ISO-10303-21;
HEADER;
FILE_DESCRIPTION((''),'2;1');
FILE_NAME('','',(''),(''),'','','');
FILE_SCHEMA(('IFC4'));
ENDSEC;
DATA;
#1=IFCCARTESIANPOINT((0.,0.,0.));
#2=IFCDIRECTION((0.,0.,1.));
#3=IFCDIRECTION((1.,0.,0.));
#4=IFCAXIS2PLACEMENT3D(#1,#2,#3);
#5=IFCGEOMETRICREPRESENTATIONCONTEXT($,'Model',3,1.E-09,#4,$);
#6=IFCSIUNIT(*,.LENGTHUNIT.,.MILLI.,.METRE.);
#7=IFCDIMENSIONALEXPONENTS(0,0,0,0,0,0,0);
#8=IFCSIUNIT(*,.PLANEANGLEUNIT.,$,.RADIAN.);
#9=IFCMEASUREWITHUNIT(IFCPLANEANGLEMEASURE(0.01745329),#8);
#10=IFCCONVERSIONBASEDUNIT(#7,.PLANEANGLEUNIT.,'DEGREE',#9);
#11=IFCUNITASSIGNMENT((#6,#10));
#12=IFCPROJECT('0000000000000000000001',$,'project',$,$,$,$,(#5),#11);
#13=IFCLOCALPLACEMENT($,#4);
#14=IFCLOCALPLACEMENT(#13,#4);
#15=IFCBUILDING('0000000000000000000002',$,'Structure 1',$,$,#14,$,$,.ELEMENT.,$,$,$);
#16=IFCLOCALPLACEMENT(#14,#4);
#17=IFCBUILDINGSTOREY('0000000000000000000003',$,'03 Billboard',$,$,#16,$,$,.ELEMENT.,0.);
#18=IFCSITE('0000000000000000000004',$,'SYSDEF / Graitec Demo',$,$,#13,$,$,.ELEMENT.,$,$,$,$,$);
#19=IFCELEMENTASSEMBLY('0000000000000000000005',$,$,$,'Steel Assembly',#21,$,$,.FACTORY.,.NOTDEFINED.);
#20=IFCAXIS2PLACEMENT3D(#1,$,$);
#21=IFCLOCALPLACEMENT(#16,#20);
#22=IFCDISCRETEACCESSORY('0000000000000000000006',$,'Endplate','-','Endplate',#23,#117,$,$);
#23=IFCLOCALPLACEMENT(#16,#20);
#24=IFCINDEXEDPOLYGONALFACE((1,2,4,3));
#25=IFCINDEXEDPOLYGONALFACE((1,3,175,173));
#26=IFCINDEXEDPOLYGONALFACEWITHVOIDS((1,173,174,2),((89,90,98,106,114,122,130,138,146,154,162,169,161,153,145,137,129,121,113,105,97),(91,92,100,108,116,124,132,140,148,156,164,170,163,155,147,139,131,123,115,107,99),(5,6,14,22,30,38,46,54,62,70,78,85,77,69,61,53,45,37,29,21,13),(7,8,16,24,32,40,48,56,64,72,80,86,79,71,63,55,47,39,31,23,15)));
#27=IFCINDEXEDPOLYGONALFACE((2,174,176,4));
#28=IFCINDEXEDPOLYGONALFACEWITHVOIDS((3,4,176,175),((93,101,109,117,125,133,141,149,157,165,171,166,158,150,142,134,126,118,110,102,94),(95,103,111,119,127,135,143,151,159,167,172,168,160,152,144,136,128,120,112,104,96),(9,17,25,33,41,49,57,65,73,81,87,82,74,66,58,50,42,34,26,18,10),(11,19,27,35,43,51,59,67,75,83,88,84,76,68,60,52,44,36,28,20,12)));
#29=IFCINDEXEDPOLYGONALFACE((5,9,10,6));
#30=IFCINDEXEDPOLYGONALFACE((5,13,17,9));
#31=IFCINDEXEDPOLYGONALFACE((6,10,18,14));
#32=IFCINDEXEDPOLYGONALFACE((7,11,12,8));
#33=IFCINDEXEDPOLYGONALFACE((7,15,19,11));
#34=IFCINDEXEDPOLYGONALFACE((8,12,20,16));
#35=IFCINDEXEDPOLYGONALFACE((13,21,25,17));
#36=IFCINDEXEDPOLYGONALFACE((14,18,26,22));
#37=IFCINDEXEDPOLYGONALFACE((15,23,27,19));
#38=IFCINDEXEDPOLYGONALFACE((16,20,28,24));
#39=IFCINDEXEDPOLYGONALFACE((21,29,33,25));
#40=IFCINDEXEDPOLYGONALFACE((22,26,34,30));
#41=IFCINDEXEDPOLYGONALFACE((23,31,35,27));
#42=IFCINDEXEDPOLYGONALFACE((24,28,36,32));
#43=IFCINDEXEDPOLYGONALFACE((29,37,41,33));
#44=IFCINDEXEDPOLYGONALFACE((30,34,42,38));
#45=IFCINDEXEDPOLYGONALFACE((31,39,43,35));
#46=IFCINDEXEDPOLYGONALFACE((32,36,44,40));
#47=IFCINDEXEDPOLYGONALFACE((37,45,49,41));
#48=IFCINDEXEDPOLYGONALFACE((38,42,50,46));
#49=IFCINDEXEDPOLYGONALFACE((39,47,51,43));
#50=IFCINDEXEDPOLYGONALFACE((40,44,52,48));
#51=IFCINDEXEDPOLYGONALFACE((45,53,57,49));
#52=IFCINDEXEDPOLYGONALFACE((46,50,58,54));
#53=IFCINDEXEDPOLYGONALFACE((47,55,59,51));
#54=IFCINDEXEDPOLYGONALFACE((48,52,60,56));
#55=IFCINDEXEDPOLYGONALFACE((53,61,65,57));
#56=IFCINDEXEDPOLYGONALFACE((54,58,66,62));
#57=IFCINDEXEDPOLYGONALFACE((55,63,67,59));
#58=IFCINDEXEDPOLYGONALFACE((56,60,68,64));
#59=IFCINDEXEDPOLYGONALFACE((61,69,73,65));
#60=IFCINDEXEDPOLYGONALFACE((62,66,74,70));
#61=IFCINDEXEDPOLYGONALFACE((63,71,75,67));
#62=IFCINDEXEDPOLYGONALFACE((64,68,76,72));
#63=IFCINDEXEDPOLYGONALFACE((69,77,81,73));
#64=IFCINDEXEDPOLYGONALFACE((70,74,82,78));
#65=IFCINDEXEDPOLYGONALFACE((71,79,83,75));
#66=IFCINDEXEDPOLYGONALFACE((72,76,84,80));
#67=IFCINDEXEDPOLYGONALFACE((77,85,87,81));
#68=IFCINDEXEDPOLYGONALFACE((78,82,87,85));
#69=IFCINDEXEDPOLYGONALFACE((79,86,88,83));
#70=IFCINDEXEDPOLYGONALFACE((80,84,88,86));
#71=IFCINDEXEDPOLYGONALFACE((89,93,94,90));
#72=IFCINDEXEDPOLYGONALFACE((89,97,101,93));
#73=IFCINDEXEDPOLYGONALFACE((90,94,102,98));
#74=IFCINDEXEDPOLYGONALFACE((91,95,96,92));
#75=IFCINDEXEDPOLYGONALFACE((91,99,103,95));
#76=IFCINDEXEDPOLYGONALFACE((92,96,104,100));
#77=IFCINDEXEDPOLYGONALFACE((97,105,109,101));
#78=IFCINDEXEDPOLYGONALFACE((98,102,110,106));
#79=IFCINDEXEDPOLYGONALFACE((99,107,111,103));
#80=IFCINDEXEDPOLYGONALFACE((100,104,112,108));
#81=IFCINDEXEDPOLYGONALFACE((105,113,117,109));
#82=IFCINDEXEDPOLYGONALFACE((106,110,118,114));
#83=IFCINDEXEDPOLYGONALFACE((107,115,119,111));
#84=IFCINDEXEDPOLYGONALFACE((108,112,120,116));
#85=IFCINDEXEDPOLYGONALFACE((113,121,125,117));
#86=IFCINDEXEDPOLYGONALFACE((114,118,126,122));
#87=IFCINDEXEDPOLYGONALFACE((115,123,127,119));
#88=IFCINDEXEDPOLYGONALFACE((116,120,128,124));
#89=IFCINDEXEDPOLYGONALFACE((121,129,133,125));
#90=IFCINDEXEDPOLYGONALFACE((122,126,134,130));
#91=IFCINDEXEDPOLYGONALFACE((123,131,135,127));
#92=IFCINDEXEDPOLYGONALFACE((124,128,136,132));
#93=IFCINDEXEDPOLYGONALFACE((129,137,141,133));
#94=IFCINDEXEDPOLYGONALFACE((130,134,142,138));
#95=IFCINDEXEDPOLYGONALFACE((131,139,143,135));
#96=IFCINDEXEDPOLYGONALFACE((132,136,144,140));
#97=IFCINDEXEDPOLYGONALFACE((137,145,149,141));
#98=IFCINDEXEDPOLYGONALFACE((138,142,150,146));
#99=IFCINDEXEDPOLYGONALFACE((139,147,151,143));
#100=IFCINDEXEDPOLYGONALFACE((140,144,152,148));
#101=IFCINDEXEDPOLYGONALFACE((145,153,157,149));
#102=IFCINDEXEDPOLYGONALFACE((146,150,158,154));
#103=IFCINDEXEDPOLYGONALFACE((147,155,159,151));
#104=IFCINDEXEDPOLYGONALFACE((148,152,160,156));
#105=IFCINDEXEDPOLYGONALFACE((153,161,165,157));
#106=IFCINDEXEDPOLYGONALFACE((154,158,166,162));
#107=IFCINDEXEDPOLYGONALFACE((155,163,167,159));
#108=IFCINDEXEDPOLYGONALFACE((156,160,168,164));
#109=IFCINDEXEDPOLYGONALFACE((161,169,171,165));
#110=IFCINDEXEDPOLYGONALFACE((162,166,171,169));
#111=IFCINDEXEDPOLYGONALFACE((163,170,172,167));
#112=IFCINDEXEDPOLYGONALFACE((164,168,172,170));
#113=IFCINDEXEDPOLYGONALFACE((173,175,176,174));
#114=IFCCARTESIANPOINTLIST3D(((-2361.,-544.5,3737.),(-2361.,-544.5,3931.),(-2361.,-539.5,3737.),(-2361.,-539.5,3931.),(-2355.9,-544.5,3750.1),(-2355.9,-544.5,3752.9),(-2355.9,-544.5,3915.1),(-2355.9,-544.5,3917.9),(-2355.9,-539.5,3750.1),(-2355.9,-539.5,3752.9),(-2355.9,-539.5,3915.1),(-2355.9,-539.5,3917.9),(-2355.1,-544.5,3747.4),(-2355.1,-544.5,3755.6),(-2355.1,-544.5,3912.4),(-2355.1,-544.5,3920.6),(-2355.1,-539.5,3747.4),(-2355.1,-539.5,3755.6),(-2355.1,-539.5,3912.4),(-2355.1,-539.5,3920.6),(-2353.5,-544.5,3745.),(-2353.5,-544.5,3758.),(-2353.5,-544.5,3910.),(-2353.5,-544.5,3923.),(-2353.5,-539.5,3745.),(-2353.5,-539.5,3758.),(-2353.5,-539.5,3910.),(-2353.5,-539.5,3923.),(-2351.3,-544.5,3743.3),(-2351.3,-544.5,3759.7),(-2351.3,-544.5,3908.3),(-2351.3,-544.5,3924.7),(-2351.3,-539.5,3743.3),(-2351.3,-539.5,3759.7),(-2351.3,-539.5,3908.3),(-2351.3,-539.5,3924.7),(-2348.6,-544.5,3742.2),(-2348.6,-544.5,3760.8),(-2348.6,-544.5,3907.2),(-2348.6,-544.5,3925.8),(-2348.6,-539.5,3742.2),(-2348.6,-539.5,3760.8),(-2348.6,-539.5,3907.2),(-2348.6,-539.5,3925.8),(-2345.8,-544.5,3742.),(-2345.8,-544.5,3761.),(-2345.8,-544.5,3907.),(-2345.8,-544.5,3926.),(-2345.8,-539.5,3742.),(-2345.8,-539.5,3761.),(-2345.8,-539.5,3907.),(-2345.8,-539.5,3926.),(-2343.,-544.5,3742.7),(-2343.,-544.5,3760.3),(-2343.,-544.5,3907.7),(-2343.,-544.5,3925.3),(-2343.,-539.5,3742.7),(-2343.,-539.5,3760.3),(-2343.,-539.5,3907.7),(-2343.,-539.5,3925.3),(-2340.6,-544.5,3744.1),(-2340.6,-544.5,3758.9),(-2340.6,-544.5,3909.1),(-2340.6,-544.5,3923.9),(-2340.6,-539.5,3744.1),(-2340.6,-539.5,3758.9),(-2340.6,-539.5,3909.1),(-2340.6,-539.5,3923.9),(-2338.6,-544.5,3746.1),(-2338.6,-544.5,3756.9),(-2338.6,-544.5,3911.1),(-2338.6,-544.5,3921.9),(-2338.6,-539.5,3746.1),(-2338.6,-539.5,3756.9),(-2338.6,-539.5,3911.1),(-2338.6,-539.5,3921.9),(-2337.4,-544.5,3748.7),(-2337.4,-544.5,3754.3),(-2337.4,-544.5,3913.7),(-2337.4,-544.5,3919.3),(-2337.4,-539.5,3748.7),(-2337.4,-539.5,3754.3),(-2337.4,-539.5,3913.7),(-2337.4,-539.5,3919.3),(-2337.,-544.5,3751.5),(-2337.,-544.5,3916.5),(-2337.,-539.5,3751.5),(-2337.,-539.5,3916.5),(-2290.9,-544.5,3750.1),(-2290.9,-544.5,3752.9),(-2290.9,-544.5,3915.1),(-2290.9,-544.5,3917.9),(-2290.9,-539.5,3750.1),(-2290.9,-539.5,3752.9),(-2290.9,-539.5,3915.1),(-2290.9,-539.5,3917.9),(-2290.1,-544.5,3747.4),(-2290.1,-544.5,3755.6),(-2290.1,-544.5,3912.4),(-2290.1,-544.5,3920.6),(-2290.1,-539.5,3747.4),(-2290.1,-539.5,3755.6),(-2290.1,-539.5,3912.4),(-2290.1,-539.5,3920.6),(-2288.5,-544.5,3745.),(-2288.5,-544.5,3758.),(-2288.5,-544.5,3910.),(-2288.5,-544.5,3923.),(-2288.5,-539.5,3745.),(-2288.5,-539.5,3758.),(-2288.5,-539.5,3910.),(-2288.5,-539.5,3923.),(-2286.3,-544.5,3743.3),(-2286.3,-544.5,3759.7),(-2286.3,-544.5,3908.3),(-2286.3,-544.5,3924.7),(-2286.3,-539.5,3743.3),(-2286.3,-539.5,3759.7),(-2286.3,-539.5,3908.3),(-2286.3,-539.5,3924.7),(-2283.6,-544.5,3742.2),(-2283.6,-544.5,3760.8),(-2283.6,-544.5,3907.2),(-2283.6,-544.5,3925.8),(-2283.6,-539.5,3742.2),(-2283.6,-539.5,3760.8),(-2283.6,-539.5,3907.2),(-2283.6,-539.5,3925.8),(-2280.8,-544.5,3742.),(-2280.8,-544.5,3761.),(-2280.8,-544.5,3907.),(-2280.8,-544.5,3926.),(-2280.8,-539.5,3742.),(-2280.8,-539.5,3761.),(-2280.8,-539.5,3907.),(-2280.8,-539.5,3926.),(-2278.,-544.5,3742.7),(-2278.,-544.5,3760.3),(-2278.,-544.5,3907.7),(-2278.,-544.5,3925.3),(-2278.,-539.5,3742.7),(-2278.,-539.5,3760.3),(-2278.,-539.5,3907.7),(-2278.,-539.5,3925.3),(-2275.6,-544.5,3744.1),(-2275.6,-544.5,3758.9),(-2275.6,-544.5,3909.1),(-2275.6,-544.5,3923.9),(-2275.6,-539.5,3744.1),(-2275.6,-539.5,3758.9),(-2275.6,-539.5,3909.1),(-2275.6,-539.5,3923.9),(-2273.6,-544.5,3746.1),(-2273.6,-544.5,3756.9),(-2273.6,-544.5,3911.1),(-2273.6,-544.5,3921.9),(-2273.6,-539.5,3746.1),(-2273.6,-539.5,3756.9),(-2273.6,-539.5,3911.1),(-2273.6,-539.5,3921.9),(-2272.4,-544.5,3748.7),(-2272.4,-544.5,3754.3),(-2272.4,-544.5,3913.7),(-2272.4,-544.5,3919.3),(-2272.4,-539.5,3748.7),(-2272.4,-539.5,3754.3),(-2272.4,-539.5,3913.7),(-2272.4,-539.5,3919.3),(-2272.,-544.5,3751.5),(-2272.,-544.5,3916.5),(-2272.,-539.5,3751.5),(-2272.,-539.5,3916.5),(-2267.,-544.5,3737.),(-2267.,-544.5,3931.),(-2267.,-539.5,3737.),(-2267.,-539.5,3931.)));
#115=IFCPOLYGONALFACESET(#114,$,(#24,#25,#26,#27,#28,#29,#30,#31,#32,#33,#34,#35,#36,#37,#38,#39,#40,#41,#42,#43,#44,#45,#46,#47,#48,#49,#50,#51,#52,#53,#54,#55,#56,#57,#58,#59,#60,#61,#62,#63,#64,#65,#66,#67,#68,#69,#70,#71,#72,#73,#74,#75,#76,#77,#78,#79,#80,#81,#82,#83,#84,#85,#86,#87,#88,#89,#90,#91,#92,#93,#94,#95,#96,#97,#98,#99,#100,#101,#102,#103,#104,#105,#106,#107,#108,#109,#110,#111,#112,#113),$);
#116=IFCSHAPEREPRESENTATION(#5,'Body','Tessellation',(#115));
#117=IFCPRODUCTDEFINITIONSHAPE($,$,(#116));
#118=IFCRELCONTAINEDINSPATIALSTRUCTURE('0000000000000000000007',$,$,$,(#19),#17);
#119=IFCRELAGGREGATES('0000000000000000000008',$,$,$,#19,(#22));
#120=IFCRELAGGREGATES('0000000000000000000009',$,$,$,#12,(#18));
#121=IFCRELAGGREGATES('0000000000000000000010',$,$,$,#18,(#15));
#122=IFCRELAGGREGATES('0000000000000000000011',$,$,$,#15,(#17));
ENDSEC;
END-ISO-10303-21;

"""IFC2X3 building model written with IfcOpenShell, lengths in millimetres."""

from ifc_helpers import new_model, entity, si_unit, converted_unit, frame, frame_2d, origin, origin_with_axes, place, context, project, spatial, polyline, circle, outline, extrude, element, aggregate, save


model = new_model("IFC2X3")

# Units and contexts
model_context = context("Model", 3, precision=1e-09, world=origin_with_axes())
ifc_project = project(units=[si_unit("LENGTHUNIT", "METRE", prefix="MILLI"), converted_unit("PLANEANGLEUNIT", "DEGREE", entity("IfcPlaneAngleMeasure", 0.01745329), si_unit("PLANEANGLEUNIT", "RADIAN"), dimensions=[0, 0, 0, 0, 0, 0, 0])], contexts=[model_context])

# Site, building, storey
site_placement = place(None, origin_with_axes())
site = spatial("IfcSite", under=ifc_project, at=site_placement, Name="SYSDEF / Graitec Demo", CompositionType="ELEMENT")
building_placement = place(site_placement, origin_with_axes())
building = spatial("IfcBuilding", under=site, at=building_placement, Name="Structure 1", CompositionType="ELEMENT")
storey_placement = place(building_placement, origin_with_axes())
storey = spatial("IfcBuildingStorey", under=building, at=storey_placement, Name="03 Billboard", CompositionType="ELEMENT", Elevation=0.0)

# Element assembly
assembly_1_placement = place(None, frame((-4406.3, 0.0, 3558.0), z_axis=(-1.0, 0.0, 0.0), x_axis=(0.0, -1.0, 0.0)))
assembly_1 = element("IfcElementAssembly", 1, at=assembly_1_placement, inside=storey, ObjectType="Steel Assembly", AssemblyPlace="FACTORY", PredefinedType="NOTDEFINED")

# Discrete accessory, openings
discrete_accessory_1_placement = place(assembly_1_placement, frame((539.5, 373.0, -2139.3), z_axis=(1.0, 0.0, 0.0), x_axis=(0.0, 0.0, 1.0)))
discrete_accessory_1 = element("IfcDiscreteAccessory", 2, at=discrete_accessory_1_placement, Name="Endplate", Description="-", ObjectType="Endplate", context=model_context, shape_type="SweptSolid", body=[
    extrude(outline(polyline([(0.0, 0.0), (94.0, 0.0), (94.0, 194.0), (0.0, 194.0), (0.0, 0.0)])), origin_with_axes(), (0.0, 0.0, 1.0), 5.0),
])
opening_1_placement = place(discrete_accessory_1_placement, frame((47.0, 97.0, -0.5), z_axis=(0.0, 0.0, 1.0), x_axis=(-1.0, 0.0, 0.0)))
element("IfcOpeningElement", 3, at=opening_1_placement, cuts=discrete_accessory_1, ObjectType="Opening", context=model_context, shape_type="SweptSolid", body=[
    extrude(circle(Radius=9.5, at=frame_2d((32.5, 82.5), x_axis=(1.0, 0.0))), origin(), (0.0, 0.0, 1.0), 6.0),
])
opening_2_placement = place(discrete_accessory_1_placement, frame((47.0, 97.0, -0.5), z_axis=(0.0, 0.0, 1.0), x_axis=(-1.0, 0.0, 0.0)))
element("IfcOpeningElement", 4, at=opening_2_placement, cuts=discrete_accessory_1, ObjectType="Opening", context=model_context, shape_type="SweptSolid", body=[
    extrude(circle(Radius=9.5, at=frame_2d((-32.5, 82.5), x_axis=(1.0, 0.0))), origin(), (0.0, 0.0, 1.0), 6.0),
])
opening_3_placement = place(discrete_accessory_1_placement, frame((47.0, 97.0, -0.5), z_axis=(0.0, 0.0, 1.0), x_axis=(-1.0, 0.0, 0.0)))
element("IfcOpeningElement", 5, at=opening_3_placement, cuts=discrete_accessory_1, ObjectType="Opening", context=model_context, shape_type="SweptSolid", body=[
    extrude(circle(Radius=9.5, at=frame_2d((32.5, -82.5), x_axis=(1.0, 0.0))), origin(), (0.0, 0.0, 1.0), 6.0),
])
opening_4_placement = place(discrete_accessory_1_placement, frame((47.0, 97.0, -0.5), z_axis=(0.0, 0.0, 1.0), x_axis=(-1.0, 0.0, 0.0)))
element("IfcOpeningElement", 6, at=opening_4_placement, cuts=discrete_accessory_1, ObjectType="Opening", context=model_context, shape_type="SweptSolid", body=[
    extrude(circle(Radius=9.5, at=frame_2d((-32.5, -82.5), x_axis=(1.0, 0.0))), origin(), (0.0, 0.0, 1.0), 6.0),
])
aggregate(assembly_1, [discrete_accessory_1])

save(model, "model.ifc")
